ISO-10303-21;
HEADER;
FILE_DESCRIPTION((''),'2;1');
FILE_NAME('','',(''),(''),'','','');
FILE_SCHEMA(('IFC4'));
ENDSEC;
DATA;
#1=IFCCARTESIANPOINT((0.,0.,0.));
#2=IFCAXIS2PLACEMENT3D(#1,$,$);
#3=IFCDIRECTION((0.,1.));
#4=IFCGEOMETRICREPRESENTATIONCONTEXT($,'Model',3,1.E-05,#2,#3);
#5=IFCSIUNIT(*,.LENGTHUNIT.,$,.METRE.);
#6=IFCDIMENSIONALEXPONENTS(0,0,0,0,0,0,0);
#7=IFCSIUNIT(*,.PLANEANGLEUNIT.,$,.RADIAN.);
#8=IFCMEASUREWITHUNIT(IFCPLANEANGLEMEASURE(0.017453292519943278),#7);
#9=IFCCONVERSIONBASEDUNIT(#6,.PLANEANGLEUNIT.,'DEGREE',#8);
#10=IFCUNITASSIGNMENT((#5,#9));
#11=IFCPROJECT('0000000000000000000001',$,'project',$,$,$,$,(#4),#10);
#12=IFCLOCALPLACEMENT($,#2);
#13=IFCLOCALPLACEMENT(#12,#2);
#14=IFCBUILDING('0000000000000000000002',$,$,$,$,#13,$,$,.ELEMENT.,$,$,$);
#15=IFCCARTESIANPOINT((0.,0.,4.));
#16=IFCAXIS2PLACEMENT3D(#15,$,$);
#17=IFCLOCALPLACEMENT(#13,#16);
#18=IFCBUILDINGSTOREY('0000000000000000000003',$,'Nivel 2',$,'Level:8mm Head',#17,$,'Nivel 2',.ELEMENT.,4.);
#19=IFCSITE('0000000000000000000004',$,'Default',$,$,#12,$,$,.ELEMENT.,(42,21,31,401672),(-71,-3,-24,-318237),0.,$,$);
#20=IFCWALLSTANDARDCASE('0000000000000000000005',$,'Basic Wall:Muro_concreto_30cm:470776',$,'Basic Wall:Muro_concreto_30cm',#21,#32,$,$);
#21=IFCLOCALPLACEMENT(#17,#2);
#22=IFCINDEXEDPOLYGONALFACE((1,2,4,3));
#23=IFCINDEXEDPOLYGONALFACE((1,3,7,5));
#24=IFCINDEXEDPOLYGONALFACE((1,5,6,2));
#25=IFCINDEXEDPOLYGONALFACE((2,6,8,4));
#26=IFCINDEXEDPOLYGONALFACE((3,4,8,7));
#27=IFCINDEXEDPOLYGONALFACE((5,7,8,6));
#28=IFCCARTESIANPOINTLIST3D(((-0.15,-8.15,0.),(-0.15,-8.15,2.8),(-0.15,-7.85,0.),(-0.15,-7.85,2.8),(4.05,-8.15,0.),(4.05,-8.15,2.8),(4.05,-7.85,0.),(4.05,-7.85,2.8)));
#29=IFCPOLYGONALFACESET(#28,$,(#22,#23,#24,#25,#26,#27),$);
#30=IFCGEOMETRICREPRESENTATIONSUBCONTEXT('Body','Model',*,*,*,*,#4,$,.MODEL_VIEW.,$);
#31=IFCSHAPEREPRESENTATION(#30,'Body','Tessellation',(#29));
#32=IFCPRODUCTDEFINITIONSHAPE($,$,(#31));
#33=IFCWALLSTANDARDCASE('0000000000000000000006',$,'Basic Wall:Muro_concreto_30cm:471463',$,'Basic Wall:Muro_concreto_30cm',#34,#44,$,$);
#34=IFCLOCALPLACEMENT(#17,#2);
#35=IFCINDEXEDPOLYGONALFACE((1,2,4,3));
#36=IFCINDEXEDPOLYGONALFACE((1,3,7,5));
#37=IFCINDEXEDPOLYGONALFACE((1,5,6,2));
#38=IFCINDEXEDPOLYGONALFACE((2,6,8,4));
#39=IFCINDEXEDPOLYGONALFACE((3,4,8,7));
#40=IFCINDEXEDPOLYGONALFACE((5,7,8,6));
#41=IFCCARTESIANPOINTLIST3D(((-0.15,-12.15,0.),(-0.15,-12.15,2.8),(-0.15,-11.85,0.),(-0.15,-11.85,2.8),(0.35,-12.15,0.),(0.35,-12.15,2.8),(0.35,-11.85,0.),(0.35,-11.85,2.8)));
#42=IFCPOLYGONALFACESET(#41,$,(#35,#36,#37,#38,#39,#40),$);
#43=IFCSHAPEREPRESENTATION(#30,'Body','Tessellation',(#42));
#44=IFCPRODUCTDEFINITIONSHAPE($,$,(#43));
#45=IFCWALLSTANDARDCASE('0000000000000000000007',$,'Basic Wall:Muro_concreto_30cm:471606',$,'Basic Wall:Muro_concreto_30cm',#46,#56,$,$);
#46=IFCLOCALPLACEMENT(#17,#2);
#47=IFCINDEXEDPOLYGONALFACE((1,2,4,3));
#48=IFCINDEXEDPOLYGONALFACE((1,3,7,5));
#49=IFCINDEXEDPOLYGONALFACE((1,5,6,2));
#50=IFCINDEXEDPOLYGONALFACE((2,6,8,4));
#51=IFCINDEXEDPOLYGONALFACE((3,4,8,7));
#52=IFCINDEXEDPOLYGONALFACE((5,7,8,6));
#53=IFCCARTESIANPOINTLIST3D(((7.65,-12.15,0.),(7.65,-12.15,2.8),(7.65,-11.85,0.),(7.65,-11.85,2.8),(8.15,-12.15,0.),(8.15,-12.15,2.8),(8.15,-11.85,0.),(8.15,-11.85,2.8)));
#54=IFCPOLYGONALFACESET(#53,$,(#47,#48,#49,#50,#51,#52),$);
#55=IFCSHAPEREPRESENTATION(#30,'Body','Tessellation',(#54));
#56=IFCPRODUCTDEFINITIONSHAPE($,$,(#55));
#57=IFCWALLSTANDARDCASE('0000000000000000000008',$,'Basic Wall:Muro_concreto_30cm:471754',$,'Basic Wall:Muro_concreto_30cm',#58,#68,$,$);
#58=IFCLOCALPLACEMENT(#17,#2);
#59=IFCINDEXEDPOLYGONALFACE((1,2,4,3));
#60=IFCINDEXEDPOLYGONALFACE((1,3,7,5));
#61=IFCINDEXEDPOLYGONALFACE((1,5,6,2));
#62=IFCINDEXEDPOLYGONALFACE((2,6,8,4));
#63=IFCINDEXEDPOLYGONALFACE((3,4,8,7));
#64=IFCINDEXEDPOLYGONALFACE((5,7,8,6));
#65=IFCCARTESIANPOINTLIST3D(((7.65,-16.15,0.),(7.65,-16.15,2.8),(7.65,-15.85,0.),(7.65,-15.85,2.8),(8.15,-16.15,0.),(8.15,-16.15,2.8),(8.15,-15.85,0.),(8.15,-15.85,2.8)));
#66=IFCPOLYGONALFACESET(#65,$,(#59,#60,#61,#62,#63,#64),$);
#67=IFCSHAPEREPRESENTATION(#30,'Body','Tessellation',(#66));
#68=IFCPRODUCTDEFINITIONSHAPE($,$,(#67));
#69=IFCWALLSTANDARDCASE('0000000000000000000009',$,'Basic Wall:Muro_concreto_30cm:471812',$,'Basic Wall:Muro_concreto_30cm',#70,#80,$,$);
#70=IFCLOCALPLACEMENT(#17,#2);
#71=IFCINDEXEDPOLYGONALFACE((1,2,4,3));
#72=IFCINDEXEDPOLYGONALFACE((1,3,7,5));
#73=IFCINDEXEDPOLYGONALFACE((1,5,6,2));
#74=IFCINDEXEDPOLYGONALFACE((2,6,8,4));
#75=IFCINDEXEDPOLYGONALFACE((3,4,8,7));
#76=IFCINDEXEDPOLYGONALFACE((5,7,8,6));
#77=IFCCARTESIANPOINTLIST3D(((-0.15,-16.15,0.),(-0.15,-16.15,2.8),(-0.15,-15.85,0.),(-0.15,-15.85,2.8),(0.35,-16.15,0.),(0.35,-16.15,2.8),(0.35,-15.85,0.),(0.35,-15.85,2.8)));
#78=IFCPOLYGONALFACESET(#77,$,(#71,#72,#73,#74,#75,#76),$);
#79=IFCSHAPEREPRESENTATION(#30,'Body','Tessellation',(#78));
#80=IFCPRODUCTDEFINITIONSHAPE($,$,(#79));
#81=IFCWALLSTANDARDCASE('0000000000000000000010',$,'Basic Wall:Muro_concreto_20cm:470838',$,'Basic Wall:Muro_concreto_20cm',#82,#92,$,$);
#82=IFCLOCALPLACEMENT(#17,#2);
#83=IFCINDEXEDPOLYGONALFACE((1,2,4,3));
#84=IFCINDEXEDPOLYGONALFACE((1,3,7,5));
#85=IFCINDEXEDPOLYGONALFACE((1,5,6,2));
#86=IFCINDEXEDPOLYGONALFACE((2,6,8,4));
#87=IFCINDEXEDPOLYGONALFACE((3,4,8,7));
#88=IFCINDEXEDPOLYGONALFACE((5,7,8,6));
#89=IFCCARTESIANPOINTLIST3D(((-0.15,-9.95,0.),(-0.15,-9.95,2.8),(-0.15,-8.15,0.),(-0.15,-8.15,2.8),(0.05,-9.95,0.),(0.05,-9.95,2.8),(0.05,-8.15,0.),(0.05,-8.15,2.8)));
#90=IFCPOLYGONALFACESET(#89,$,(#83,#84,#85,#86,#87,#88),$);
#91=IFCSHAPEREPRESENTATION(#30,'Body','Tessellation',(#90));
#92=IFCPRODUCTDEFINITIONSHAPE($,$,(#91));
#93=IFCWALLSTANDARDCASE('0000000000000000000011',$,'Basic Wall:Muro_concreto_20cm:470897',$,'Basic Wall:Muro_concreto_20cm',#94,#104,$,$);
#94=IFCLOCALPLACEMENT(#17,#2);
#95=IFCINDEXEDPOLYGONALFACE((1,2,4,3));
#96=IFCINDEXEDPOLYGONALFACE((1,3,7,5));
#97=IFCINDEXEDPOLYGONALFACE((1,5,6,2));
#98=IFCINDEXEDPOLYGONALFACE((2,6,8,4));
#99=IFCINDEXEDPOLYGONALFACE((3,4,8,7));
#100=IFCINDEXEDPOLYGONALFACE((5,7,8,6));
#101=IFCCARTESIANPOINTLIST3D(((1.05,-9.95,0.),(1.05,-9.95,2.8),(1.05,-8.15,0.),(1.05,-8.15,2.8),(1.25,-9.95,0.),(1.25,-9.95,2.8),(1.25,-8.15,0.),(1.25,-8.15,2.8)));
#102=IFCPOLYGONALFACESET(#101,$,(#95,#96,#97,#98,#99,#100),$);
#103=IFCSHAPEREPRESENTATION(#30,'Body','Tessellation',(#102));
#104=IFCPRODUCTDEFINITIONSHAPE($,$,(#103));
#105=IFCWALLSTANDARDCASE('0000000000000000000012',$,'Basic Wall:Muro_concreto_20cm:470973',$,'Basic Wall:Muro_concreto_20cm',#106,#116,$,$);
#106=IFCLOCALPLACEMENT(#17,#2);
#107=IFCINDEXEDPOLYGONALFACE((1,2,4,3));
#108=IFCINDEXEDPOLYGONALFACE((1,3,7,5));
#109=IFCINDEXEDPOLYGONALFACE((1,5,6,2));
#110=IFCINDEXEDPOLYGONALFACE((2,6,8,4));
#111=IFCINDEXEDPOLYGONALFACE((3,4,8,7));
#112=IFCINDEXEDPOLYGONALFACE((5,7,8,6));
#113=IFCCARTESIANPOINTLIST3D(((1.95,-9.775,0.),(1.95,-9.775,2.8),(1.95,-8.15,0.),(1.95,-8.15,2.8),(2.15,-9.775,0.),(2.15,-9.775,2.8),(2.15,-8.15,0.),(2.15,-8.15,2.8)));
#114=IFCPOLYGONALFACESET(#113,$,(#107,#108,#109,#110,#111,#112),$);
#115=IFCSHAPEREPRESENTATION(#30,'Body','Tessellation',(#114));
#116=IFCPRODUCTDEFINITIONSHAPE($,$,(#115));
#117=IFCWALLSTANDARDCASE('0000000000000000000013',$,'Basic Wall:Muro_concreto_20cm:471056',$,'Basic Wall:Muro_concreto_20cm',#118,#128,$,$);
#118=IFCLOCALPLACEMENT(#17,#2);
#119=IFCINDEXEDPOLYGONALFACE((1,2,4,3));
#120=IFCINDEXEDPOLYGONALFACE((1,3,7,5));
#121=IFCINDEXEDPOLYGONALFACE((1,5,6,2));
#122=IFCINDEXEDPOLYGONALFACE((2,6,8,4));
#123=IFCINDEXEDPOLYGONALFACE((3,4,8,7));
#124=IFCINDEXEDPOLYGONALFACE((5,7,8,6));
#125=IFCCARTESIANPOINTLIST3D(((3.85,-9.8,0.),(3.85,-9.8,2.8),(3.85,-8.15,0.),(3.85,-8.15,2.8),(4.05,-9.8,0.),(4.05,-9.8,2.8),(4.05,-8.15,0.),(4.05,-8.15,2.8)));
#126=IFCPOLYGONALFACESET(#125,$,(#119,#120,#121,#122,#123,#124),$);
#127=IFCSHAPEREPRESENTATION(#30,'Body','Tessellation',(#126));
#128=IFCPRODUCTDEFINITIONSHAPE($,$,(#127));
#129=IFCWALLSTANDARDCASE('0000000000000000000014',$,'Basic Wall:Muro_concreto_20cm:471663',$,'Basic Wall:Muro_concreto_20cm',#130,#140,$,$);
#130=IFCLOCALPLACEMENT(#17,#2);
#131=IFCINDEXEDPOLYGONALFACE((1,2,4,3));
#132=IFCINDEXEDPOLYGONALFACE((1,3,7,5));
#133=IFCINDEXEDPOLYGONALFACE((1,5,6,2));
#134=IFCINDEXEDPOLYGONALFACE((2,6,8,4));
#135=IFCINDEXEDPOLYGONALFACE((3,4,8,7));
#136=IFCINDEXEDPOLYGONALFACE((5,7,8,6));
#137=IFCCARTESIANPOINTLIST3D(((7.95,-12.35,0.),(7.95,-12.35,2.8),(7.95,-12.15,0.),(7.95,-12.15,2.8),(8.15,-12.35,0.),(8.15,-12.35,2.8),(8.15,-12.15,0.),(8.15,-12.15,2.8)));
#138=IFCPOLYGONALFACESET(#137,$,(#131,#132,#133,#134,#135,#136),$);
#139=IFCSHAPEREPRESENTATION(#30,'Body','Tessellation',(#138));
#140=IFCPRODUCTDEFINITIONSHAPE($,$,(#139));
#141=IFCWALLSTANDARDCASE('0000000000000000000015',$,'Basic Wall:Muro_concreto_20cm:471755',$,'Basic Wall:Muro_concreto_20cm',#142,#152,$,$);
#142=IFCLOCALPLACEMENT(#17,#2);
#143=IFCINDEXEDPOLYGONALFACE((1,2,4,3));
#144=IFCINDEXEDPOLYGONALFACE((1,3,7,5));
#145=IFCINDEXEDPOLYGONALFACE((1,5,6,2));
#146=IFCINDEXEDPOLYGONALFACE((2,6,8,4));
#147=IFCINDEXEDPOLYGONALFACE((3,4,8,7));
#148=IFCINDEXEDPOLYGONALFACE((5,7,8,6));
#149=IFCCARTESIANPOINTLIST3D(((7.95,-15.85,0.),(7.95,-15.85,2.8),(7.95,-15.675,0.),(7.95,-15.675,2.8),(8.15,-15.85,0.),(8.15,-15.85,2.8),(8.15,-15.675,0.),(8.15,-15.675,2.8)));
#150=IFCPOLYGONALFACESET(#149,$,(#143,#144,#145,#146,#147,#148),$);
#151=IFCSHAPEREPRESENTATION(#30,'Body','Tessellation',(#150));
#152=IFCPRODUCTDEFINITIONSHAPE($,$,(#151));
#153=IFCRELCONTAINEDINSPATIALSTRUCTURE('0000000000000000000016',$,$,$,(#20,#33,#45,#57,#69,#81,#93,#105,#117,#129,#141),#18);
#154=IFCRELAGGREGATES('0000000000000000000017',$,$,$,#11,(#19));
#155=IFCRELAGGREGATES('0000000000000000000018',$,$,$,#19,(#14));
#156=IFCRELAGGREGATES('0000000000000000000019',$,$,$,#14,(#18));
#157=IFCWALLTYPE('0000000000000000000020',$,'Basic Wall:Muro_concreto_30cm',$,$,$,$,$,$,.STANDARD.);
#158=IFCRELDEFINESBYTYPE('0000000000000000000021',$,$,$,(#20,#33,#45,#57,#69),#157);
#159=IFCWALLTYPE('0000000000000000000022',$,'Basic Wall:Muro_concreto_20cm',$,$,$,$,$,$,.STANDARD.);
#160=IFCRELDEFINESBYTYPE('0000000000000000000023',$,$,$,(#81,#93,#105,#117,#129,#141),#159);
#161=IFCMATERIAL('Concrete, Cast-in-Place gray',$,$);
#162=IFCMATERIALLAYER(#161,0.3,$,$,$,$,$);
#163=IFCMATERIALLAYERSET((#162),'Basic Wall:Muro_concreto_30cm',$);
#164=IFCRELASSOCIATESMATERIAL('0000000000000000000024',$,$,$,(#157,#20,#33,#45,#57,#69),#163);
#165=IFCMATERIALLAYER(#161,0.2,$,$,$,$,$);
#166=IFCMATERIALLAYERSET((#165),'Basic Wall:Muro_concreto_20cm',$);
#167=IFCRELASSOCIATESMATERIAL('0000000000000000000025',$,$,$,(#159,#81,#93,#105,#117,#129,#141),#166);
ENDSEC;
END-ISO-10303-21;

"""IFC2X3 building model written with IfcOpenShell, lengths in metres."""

from ifc_helpers import new_model, entity, si_unit, converted_unit, direction, frame, frame_2d, origin, place, context, subcontext, project, spatial, polyline, rectangle, extrude, clip, bounded_halfspace, material, layer, layer_set, layer_usage, type_object, element, save


model = new_model("IFC2X3")

# Units and contexts
model_context = context("Model", 3, precision=1e-05, world=origin(), true_north=direction((0.0, 1.0)))
body_context = subcontext(model_context, "Body", "Model", "MODEL_VIEW")
ifc_project = project(units=[si_unit("LENGTHUNIT", "METRE"), converted_unit("PLANEANGLEUNIT", "DEGREE", entity("IfcPlaneAngleMeasure", 0.017453292519943278), si_unit("PLANEANGLEUNIT", "RADIAN"), dimensions=[0, 0, 0, 0, 0, 0, 0])], contexts=[model_context])

# Site, building, storey
site_placement = place(None, origin())
site = spatial("IfcSite", under=ifc_project, at=site_placement, Name="Default", CompositionType="ELEMENT", RefLatitude=(42, 21, 31, 401672), RefLongitude=(-71, -3, -24, -318237), RefElevation=0.0)
building_placement = place(site_placement, origin())
building = spatial("IfcBuilding", under=site, at=building_placement, CompositionType="ELEMENT")
storey_placement = place(building_placement, frame((0.0, 0.0, 4.0)))
storey = spatial("IfcBuildingStorey", under=building, at=storey_placement, Name="Nivel 2", ObjectType="Level:8mm Head", LongName="Nivel 2", CompositionType="ELEMENT", Elevation=4.0)

# Shared definitions
ifc_material_1 = material(Name="Concrete, Cast-in-Place gray")

# Walls
ifc_layer_1 = layer(ifc_material_1, 0.3)
ifc_layer_set_1 = layer_set([ifc_layer_1], Name="Basic Wall:Muro_concreto_30cm")
ifc_layer_usage_1 = layer_usage(ifc_layer_set_1, "AXIS2", "NEGATIVE", 0.15)
wall_type_1 = type_object("IfcWallType", Name="Basic Wall:Muro_concreto_30cm", PredefinedType="STANDARD", material=ifc_layer_set_1)
wall_1_placement = place(storey_placement, frame((-0.15, -8.0, 0.0)))
element("IfcWallStandardCase", 1, at=wall_1_placement, inside=storey, type_object=wall_type_1, material=ifc_layer_usage_1, Name="Basic Wall:Muro_concreto_30cm:470776", ObjectType="Basic Wall:Muro_concreto_30cm", context=body_context, shape_type="Clipping", body=[
    clip(extrude(rectangle(XDim=4.2, YDim=0.3, at=frame_2d((2.1, 0.0), x_axis=(-1.0, 0.0))), origin(), (0.0, 0.0, 1.0), 2.8), bounded_halfspace(frame((0.0, -0.15, 2.8), z_axis=(0.0, 0.0, -1.0), x_axis=(0.0, -1.0, 0.0)), True, frame((0.0, -0.15, 2.8)), polyline([(0.0, 0.0), (0.2, 0.0), (1.2, 0.0), (1.4, 0.0), (2.1, 0.0), (2.3, 0.0), (4.0, 0.0), (4.2, 0.0), (4.2, 0.15), (4.2, 0.3), (4.0, 0.3), (0.0, 0.3), (0.0, 0.0)]))),
])
ifc_layer_usage_2 = layer_usage(ifc_layer_set_1, "AXIS2", "NEGATIVE", 0.15)
wall_2_placement = place(storey_placement, frame((0.35, -12.0, 0.0), z_axis=(0.0, 0.0, 1.0), x_axis=(-1.0, 0.0, 0.0)))
element("IfcWallStandardCase", 2, at=wall_2_placement, inside=storey, type_object=wall_type_1, material=ifc_layer_usage_2, Name="Basic Wall:Muro_concreto_30cm:471463", ObjectType="Basic Wall:Muro_concreto_30cm", context=body_context, shape_type="Clipping", body=[
    clip(extrude(rectangle(XDim=0.5, YDim=0.3, at=frame_2d((0.25, 0.0), x_axis=(-1.0, 0.0))), origin(), (0.0, 0.0, 1.0), 2.8), bounded_halfspace(frame((0.0, -0.15, 2.8), z_axis=(0.0, 0.0, -1.0), x_axis=(0.0, 1.0, 0.0)), True, frame((0.0, -0.15, 2.8)), polyline([(0.0, 0.0), (0.5, 0.0), (0.5, 0.3), (0.2, 0.3), (0.0, 0.3), (0.0, 0.0)]))),
])
ifc_layer_usage_3 = layer_usage(ifc_layer_set_1, "AXIS2", "NEGATIVE", 0.15)
wall_3_placement = place(storey_placement, frame((7.65, -12.0, 0.0)))
element("IfcWallStandardCase", 3, at=wall_3_placement, inside=storey, type_object=wall_type_1, material=ifc_layer_usage_3, Name="Basic Wall:Muro_concreto_30cm:471606", ObjectType="Basic Wall:Muro_concreto_30cm", context=body_context, shape_type="Clipping", body=[
    clip(extrude(rectangle(XDim=0.5, YDim=0.3, at=frame_2d((0.25, 0.0), x_axis=(-1.0, 0.0))), origin(), (0.0, 0.0, 1.0), 2.8), bounded_halfspace(frame((0.0, -0.15, 2.8), z_axis=(0.0, 0.0, -1.0), x_axis=(0.0, -1.0, 0.0)), True, frame((0.0, -0.15, 2.8)), polyline([(0.0, 0.0), (0.3, 0.0), (0.5, 0.0), (0.5, 0.3), (0.0, 0.3), (0.0, 0.0)]))),
])
ifc_layer_usage_4 = layer_usage(ifc_layer_set_1, "AXIS2", "POSITIVE", -0.15)
wall_4_placement = place(storey_placement, frame((7.65, -16.0, 0.0)))
element("IfcWallStandardCase", 4, at=wall_4_placement, inside=storey, type_object=wall_type_1, material=ifc_layer_usage_4, Name="Basic Wall:Muro_concreto_30cm:471754", ObjectType="Basic Wall:Muro_concreto_30cm", context=body_context, shape_type="Clipping", body=[
    clip(extrude(rectangle(XDim=0.5, YDim=0.3, at=frame_2d((0.25, 0.0), x_axis=(-1.0, 0.0))), origin(), (0.0, 0.0, 1.0), 2.8), bounded_halfspace(frame((0.0, -0.15, 2.8), z_axis=(0.0, 0.0, -1.0), x_axis=(0.0, -1.0, 0.0)), True, frame((0.0, -0.15, 2.8)), polyline([(0.0, 0.0), (0.5, 0.0), (0.5, 0.3), (0.3, 0.3), (0.0, 0.3), (0.0, 0.0)]))),
])
ifc_layer_usage_5 = layer_usage(ifc_layer_set_1, "AXIS2", "NEGATIVE", 0.15)
wall_5_placement = place(storey_placement, frame((0.35, -16.0, 0.0), z_axis=(0.0, 0.0, 1.0), x_axis=(-1.0, 0.0, 0.0)))
element("IfcWallStandardCase", 5, at=wall_5_placement, inside=storey, type_object=wall_type_1, material=ifc_layer_usage_5, Name="Basic Wall:Muro_concreto_30cm:471812", ObjectType="Basic Wall:Muro_concreto_30cm", context=body_context, shape_type="Clipping", body=[
    clip(extrude(rectangle(XDim=0.5, YDim=0.3, at=frame_2d((0.25, 0.0), x_axis=(-1.0, 0.0))), origin(), (0.0, 0.0, 1.0), 2.8), bounded_halfspace(frame((0.0, -0.15, 2.8), z_axis=(0.0, 0.0, -1.0), x_axis=(0.0, 1.0, 0.0)), True, frame((0.0, -0.15, 2.8)), polyline([(0.0, 0.0), (0.3, 0.0), (0.5, 0.0), (0.5, 0.3), (0.0, 0.3), (0.0, 0.0)]))),
])
ifc_layer_2 = layer(ifc_material_1, 0.2)
ifc_layer_set_2 = layer_set([ifc_layer_2], Name="Basic Wall:Muro_concreto_20cm")
ifc_layer_usage_6 = layer_usage(ifc_layer_set_2, "AXIS2", "NEGATIVE", 0.1)
wall_type_2 = type_object("IfcWallType", Name="Basic Wall:Muro_concreto_20cm", PredefinedType="STANDARD", material=ifc_layer_set_2)
wall_6_placement = place(storey_placement, frame((-0.05, -9.95, 0.0), z_axis=(0.0, 0.0, 1.0), x_axis=(0.0, 1.0, 0.0)))
element("IfcWallStandardCase", 6, at=wall_6_placement, inside=storey, type_object=wall_type_2, material=ifc_layer_usage_6, Name="Basic Wall:Muro_concreto_20cm:470838", ObjectType="Basic Wall:Muro_concreto_20cm", context=body_context, shape_type="Clipping", body=[
    clip(extrude(rectangle(XDim=1.8, YDim=0.2, at=frame_2d((0.9, 0.0), x_axis=(-1.0, 0.0))), origin(), (0.0, 0.0, 1.0), 2.8), bounded_halfspace(frame((0.0, -0.1, 2.8), z_axis=(0.0, 0.0, -1.0), x_axis=(-1.0, 0.0, 0.0)), True, frame((0.0, -0.1, 2.8)), polyline([(0.0, 0.0), (1.8, 0.0), (1.8, 0.2), (0.0, 0.2), (0.0, 0.0)]))),
])
ifc_layer_usage_7 = layer_usage(ifc_layer_set_2, "AXIS2", "NEGATIVE", 0.1)
wall_7_placement = place(storey_placement, frame((1.15, -9.95, 0.0), z_axis=(0.0, 0.0, 1.0), x_axis=(0.0, 1.0, 0.0)))
element("IfcWallStandardCase", 7, at=wall_7_placement, inside=storey, type_object=wall_type_2, material=ifc_layer_usage_7, Name="Basic Wall:Muro_concreto_20cm:470897", ObjectType="Basic Wall:Muro_concreto_20cm", context=body_context, shape_type="Clipping", body=[
    clip(extrude(rectangle(XDim=1.8, YDim=0.2, at=frame_2d((0.9, 0.0), x_axis=(-1.0, 0.0))), origin(), (0.0, 0.0, 1.0), 2.8), bounded_halfspace(frame((0.0, -0.1, 2.8), z_axis=(0.0, 0.0, -1.0), x_axis=(-1.0, 0.0, 0.0)), True, frame((0.0, -0.1, 2.8)), polyline([(0.0, 0.0), (1.4, 0.0), (1.8, 0.0), (1.8, 0.2), (0.0, 0.2), (0.0, 0.0)]))),
])
ifc_layer_usage_8 = layer_usage(ifc_layer_set_2, "AXIS2", "NEGATIVE", 0.1)
wall_8_placement = place(storey_placement, frame((2.05, -9.775, 0.0), z_axis=(0.0, 0.0, 1.0), x_axis=(0.0, 1.0, 0.0)))
element("IfcWallStandardCase", 8, at=wall_8_placement, inside=storey, type_object=wall_type_2, material=ifc_layer_usage_8, Name="Basic Wall:Muro_concreto_20cm:470973", ObjectType="Basic Wall:Muro_concreto_20cm", context=body_context, shape_type="Clipping", body=[
    clip(extrude(rectangle(XDim=1.625, YDim=0.2, at=frame_2d((0.8125, 0.0), x_axis=(-1.0, 0.0))), origin(), (0.0, 0.0, 1.0), 2.8), bounded_halfspace(frame((0.0, -0.1, 2.8), z_axis=(0.0, 0.0, -1.0), x_axis=(-1.0, 0.0, 0.0)), True, frame((0.0, -0.1, 2.8)), polyline([(0.0, 0.0), (1.625, 0.0), (1.625, 0.2), (1.225, 0.2), (0.0, 0.2), (0.0, 0.0)]))),
])
ifc_layer_usage_9 = layer_usage(ifc_layer_set_2, "AXIS2", "NEGATIVE", 0.1)
wall_9_placement = place(storey_placement, frame((3.95, -9.8, 0.0), z_axis=(0.0, 0.0, 1.0), x_axis=(0.0, 1.0, 0.0)))
element("IfcWallStandardCase", 9, at=wall_9_placement, inside=storey, type_object=wall_type_2, material=ifc_layer_usage_9, Name="Basic Wall:Muro_concreto_20cm:471056", ObjectType="Basic Wall:Muro_concreto_20cm", context=body_context, shape_type="Clipping", body=[
    clip(extrude(rectangle(XDim=1.65, YDim=0.2, at=frame_2d((0.825, 0.0), x_axis=(-1.0, 0.0))), origin(), (0.0, 0.0, 1.0), 2.8), bounded_halfspace(frame((0.0, -0.1, 2.8), z_axis=(0.0, 0.0, -1.0), x_axis=(-1.0, 0.0, 0.0)), True, frame((0.0, -0.1, 2.8)), polyline([(0.0, 0.0), (1.65, 0.0), (1.65, 0.2), (0.0, 0.2), (0.0, 0.0)]))),
])
ifc_layer_usage_10 = layer_usage(ifc_layer_set_2, "AXIS2", "NEGATIVE", 0.1)
wall_10_placement = place(storey_placement, frame((8.05, -12.35, 0.0), z_axis=(0.0, 0.0, 1.0), x_axis=(0.0, 1.0, 0.0)))
element("IfcWallStandardCase", 10, at=wall_10_placement, inside=storey, type_object=wall_type_2, material=ifc_layer_usage_10, Name="Basic Wall:Muro_concreto_20cm:471663", ObjectType="Basic Wall:Muro_concreto_20cm", context=body_context, shape_type="Clipping", body=[
    clip(extrude(rectangle(XDim=0.2, YDim=0.2, at=frame_2d((0.1, 0.0), x_axis=(-1.0, 0.0))), origin(), (0.0, 0.0, 1.0), 2.8), bounded_halfspace(frame((0.0, -0.1, 2.8), z_axis=(0.0, 0.0, -1.0), x_axis=(-1.0, 0.0, 0.0)), True, frame((0.0, -0.1, 2.8)), polyline([(0.0, 0.0), (0.2, 0.0), (0.2, 0.2), (0.0, 0.2), (0.0, 0.0)]))),
])
ifc_layer_usage_11 = layer_usage(ifc_layer_set_2, "AXIS2", "POSITIVE", -0.1)
wall_11_placement = place(storey_placement, frame((8.05, -15.675, 0.0), z_axis=(0.0, 0.0, 1.0), x_axis=(0.0, -1.0, 0.0)))
element("IfcWallStandardCase", 11, at=wall_11_placement, inside=storey, type_object=wall_type_2, material=ifc_layer_usage_11, Name="Basic Wall:Muro_concreto_20cm:471755", ObjectType="Basic Wall:Muro_concreto_20cm", context=body_context, shape_type="Clipping", body=[
    clip(extrude(rectangle(XDim=0.175, YDim=0.2, at=frame_2d((0.0875, 0.0), x_axis=(-1.0, 0.0))), origin(), (0.0, 0.0, 1.0), 2.8), bounded_halfspace(frame((0.0, -0.1, 2.8), z_axis=(0.0, 0.0, -1.0), x_axis=(1.0, 0.0, 0.0)), True, frame((0.0, -0.1, 2.8)), polyline([(0.0, 0.0), (0.175, 0.0), (0.175, 0.2), (0.0, 0.2), (0.0, 0.0)]))),
])

save(model, "model.ifc")
